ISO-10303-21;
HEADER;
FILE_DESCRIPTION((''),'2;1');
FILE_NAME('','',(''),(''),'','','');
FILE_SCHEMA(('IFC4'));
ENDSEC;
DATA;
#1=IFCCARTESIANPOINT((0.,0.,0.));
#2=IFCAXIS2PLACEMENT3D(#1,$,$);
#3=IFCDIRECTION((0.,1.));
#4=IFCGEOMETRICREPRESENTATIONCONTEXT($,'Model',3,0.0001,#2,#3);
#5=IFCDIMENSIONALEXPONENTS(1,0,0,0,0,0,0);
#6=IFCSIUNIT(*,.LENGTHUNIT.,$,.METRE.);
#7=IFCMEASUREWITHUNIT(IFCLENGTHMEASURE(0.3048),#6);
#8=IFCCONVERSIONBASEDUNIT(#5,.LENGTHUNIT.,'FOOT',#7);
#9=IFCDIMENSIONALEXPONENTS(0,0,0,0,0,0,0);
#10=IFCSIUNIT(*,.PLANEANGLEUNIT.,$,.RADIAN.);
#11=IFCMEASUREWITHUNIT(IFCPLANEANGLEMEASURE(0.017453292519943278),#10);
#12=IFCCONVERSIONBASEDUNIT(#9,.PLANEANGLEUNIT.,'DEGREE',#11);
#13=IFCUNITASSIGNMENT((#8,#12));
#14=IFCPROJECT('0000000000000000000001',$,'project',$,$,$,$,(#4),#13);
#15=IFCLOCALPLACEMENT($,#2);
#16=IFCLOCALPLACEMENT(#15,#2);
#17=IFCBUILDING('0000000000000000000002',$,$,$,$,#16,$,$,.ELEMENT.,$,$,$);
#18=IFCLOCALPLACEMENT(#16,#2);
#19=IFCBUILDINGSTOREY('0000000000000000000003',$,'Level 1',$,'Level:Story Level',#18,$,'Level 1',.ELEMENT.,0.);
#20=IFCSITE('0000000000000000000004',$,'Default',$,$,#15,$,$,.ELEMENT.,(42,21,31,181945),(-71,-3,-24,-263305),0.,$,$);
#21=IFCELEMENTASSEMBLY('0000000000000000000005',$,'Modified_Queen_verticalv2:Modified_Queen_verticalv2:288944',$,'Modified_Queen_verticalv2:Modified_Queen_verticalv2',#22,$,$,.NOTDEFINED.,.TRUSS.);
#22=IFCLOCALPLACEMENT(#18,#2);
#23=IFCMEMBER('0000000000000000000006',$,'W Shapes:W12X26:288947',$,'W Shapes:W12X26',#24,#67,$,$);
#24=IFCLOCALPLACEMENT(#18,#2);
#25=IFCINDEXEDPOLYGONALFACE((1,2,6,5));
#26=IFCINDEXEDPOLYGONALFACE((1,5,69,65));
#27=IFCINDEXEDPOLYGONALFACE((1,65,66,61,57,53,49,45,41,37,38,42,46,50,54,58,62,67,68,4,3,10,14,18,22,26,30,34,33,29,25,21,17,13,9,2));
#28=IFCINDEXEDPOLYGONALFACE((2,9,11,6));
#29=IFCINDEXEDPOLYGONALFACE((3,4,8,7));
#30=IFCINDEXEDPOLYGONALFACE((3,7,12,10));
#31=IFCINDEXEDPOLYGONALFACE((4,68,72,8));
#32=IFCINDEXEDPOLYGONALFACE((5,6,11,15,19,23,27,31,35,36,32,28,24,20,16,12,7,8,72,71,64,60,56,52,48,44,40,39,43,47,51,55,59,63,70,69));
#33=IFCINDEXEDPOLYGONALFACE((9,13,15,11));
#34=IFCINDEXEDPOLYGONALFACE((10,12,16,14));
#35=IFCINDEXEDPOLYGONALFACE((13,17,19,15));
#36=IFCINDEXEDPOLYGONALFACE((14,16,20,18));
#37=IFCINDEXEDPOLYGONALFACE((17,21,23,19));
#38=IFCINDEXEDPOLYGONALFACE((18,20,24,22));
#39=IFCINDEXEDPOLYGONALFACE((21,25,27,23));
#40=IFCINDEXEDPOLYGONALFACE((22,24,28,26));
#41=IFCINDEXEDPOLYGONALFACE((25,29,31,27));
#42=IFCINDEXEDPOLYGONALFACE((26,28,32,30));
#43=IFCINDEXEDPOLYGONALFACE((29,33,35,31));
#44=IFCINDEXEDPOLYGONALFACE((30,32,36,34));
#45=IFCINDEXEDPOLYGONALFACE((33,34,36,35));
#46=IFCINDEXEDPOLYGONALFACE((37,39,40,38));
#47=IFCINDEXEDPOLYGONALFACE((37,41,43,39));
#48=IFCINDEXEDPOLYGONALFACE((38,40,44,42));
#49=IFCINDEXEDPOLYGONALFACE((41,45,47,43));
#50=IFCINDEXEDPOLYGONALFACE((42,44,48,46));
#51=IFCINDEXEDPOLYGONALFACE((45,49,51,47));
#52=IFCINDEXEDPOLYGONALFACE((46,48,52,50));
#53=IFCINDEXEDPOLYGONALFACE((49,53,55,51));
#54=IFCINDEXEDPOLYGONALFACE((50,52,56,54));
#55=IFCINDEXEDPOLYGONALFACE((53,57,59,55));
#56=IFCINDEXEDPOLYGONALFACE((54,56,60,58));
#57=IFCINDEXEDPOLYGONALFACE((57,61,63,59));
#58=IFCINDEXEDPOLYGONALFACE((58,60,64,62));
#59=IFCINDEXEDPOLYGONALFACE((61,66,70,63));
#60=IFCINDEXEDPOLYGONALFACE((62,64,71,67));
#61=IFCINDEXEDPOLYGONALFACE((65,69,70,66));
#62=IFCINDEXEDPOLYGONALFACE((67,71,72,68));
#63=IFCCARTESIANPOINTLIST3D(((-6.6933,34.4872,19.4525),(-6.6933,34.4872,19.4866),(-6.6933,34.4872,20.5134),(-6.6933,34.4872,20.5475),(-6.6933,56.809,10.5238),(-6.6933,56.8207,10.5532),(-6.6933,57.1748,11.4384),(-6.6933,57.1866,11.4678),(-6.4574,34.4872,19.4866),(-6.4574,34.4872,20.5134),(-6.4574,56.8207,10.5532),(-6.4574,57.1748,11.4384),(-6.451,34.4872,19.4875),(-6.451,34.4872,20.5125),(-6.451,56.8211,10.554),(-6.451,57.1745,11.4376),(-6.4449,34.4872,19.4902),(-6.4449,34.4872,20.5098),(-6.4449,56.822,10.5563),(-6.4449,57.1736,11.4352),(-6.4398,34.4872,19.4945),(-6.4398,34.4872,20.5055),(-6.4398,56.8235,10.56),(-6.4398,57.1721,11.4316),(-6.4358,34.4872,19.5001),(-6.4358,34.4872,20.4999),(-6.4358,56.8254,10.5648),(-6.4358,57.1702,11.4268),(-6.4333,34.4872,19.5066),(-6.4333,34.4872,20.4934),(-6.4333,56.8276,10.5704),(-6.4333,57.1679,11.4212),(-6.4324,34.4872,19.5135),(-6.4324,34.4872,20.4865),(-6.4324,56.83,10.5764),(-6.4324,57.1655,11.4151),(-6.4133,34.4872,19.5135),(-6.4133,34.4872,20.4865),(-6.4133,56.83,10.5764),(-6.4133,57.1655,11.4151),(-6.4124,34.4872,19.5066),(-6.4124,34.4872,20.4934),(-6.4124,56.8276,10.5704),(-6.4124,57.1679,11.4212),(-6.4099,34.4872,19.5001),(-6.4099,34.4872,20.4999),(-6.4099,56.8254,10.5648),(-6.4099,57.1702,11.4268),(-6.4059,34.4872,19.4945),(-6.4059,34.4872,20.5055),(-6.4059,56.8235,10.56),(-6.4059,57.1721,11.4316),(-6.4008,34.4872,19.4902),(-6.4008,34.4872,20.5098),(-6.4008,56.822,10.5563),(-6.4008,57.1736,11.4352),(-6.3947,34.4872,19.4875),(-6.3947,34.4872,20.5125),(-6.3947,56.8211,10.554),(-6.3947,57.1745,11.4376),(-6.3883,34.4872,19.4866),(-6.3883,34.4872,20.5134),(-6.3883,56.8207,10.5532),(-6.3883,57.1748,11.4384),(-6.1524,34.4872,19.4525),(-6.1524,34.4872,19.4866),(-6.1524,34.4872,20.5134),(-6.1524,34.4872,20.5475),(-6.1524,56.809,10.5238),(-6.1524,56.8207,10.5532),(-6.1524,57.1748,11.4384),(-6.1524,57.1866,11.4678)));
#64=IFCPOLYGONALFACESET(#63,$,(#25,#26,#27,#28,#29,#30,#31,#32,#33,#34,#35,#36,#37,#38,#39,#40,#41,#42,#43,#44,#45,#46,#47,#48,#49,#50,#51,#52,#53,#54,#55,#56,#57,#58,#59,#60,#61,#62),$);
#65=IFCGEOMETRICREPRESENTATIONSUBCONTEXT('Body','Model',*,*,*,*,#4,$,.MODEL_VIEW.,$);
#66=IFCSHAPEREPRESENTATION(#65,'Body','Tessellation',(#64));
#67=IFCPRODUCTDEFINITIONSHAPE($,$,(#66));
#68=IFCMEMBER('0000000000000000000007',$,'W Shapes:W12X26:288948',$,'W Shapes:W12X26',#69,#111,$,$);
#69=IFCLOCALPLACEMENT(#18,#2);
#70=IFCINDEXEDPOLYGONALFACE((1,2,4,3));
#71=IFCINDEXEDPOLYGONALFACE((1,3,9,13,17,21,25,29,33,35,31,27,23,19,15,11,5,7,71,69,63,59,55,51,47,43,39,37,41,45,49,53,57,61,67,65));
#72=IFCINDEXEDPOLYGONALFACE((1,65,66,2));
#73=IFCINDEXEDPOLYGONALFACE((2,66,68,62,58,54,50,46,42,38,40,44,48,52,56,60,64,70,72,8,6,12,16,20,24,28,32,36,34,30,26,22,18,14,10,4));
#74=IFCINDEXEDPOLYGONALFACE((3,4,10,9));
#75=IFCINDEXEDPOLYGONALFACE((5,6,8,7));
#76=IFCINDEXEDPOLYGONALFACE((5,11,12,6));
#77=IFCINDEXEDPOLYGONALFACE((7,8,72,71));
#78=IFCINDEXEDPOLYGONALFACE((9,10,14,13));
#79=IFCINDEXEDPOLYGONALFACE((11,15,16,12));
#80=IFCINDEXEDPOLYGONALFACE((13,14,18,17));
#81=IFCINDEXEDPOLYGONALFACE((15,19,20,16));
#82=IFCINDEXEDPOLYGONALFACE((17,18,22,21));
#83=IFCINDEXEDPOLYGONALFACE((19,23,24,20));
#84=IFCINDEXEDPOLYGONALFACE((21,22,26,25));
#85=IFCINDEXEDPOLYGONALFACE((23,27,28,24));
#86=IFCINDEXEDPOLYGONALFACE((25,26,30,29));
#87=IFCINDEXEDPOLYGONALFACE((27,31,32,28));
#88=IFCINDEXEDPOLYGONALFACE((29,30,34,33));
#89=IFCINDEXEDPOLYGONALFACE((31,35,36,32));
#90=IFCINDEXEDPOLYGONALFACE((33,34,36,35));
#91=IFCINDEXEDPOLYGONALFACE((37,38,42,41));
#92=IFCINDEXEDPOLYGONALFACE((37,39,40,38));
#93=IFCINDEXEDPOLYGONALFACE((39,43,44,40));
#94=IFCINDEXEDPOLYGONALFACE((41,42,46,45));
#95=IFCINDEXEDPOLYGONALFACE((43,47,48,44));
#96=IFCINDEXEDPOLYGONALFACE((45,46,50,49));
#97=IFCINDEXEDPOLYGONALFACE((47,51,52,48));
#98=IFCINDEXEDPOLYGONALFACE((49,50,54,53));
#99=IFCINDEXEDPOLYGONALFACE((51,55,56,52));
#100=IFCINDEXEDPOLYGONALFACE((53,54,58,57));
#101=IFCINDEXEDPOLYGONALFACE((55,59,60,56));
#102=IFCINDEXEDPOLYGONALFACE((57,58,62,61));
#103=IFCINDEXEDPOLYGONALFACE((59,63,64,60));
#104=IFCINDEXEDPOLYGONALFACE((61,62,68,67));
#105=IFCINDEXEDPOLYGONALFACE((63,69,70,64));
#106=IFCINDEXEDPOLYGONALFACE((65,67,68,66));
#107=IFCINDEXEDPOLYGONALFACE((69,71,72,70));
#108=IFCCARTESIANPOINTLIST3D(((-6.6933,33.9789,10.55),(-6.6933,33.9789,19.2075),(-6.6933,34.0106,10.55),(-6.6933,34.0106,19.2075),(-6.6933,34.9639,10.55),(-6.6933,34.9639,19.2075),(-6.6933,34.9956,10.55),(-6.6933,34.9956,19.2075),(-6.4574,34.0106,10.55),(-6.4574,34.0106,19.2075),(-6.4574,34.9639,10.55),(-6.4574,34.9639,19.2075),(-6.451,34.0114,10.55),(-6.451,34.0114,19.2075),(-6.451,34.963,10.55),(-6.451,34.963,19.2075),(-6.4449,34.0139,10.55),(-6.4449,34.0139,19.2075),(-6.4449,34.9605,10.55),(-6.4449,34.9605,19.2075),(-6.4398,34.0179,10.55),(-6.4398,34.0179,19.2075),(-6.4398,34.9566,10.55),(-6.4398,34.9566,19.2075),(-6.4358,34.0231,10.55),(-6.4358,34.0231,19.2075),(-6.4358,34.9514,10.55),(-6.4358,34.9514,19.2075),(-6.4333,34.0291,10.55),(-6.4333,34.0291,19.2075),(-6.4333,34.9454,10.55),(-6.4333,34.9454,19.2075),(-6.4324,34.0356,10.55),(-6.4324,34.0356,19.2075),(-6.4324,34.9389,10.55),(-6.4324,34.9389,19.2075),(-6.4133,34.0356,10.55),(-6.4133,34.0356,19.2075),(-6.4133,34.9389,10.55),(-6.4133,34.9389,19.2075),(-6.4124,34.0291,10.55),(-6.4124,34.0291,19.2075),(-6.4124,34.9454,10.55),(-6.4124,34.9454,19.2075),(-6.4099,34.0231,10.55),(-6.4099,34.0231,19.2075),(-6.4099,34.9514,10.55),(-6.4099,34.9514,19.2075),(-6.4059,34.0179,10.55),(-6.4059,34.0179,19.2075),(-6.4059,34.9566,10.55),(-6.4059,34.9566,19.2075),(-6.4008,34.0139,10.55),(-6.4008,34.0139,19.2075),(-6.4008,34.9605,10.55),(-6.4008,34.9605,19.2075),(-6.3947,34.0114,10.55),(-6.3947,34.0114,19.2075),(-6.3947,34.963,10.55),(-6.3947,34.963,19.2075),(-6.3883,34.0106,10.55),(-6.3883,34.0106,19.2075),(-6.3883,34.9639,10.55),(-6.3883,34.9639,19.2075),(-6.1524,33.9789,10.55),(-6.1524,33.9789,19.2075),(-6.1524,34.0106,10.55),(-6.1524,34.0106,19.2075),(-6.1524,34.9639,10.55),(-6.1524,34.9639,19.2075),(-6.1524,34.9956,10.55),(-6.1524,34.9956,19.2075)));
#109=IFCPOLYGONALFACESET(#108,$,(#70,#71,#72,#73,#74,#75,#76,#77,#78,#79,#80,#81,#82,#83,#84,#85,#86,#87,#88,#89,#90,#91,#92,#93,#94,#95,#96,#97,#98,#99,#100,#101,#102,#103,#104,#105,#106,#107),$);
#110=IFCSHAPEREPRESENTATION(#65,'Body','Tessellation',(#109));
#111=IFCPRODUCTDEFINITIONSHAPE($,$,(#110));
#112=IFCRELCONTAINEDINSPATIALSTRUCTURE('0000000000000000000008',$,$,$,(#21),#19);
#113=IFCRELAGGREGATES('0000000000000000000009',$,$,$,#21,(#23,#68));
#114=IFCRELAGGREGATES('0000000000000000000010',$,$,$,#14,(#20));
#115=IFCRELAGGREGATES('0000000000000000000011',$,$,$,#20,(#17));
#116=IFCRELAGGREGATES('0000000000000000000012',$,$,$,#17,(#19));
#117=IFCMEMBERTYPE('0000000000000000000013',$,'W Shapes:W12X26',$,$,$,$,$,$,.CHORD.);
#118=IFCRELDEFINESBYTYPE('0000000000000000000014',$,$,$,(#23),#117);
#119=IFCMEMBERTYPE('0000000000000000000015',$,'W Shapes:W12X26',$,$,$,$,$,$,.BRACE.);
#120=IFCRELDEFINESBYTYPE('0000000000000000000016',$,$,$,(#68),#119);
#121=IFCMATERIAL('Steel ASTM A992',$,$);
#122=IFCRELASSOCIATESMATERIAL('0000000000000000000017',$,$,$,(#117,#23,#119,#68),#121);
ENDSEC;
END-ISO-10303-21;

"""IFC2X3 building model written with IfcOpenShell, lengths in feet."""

from ifc_helpers import new_model, entity, si_unit, converted_unit, direction, frame, frame_2d, origin, place, context, subcontext, project, spatial, polyline, circle_curve, parameter, trimmed, segment, composite_curve, outline, extrude, clip, halfspace, source, transform, mapped, material, type_object, type_shapes, element, aggregate, save


model = new_model("IFC2X3")

# Units and contexts
model_context = context("Model", 3, precision=0.0001, world=origin(), true_north=direction((0.0, 1.0)))
body_context = subcontext(model_context, "Body", "Model", "MODEL_VIEW")
ifc_project = project(units=[converted_unit("LENGTHUNIT", "FOOT", entity("IfcLengthMeasure", 0.3048), si_unit("LENGTHUNIT", "METRE"), dimensions=[1, 0, 0, 0, 0, 0, 0]), converted_unit("PLANEANGLEUNIT", "DEGREE", entity("IfcPlaneAngleMeasure", 0.017453292519943278), si_unit("PLANEANGLEUNIT", "RADIAN"), dimensions=[0, 0, 0, 0, 0, 0, 0])], contexts=[model_context])

# Site, building, storey
site_placement = place(None, origin())
site = spatial("IfcSite", under=ifc_project, at=site_placement, Name="Default", CompositionType="ELEMENT", RefLatitude=(42, 21, 31, 181945), RefLongitude=(-71, -3, -24, -263305), RefElevation=0.0)
building_placement = place(site_placement, origin())
building = spatial("IfcBuilding", under=site, at=building_placement, CompositionType="ELEMENT")
storey_placement = place(building_placement, origin())
storey = spatial("IfcBuildingStorey", under=building, at=storey_placement, Name="Level 1", ObjectType="Level:Story Level", LongName="Level 1", CompositionType="ELEMENT", Elevation=0.0)

# Element assembly, members
assembly_placement = place(storey_placement, origin())
assembly = element("IfcElementAssembly", 1, at=assembly_placement, inside=storey, Name="Modified_Queen_verticalv2:Modified_Queen_verticalv2:288944", ObjectType="Modified_Queen_verticalv2:Modified_Queen_verticalv2", AssemblyPlace="NOTDEFINED", PredefinedType="TRUSS")
ifc_material = material(Name="Steel ASTM A992")
member_type_1 = type_object("IfcMemberType", Name="W Shapes:W12X26", PredefinedType="CHORD", material=ifc_material)
shared_shape_1 = source(origin(), body_context, "Body", "SweptSolid", [
    clip(extrude(outline(composite_curve([segment(polyline([(0.4767, -0.2704), (0.5083, -0.2704)]), True, "CONTINUOUS"), segment(polyline([(0.5083, -0.2704), (0.5083, 0.2704)]), True, "CONTINUOUS"), segment(polyline([(0.5083, 0.2704), (0.4767, 0.2704)]), True, "CONTINUOUS"), segment(polyline([(0.4767, 0.2704), (0.4767, 0.0346)]), True, "CONTINUOUS"), segment(trimmed(circle_curve(frame_2d((0.4517, 0.0346), x_axis=(1.0, 0.0)), 0.025), [parameter(270.0)], [parameter(0.0)], True, "PARAMETER"), False, "CONTINUOUS"), segment(polyline([(0.4517, 0.0096), (-0.4517, 0.0096)]), True, "CONTINUOUS"), segment(trimmed(circle_curve(frame_2d((-0.4517, 0.0346), x_axis=(0.0, -1.0)), 0.025), [parameter(270.0)], [parameter(0.0)], True, "PARAMETER"), False, "CONTINUOUS"), segment(polyline([(-0.4767, 0.0346), (-0.4767, 0.2704)]), True, "CONTINUOUS"), segment(polyline([(-0.4767, 0.2704), (-0.5083, 0.2704)]), True, "CONTINUOUS"), segment(polyline([(-0.5083, 0.2704), (-0.5083, -0.2704)]), True, "CONTINUOUS"), segment(polyline([(-0.5083, -0.2704), (-0.4767, -0.2704)]), True, "CONTINUOUS"), segment(polyline([(-0.4767, -0.2704), (-0.4767, -0.0346)]), True, "CONTINUOUS"), segment(trimmed(circle_curve(frame_2d((-0.4517, -0.0346), x_axis=(-1.0, 0.0)), 0.025), [parameter(270.0)], [parameter(0.0)], True, "PARAMETER"), False, "CONTINUOUS"), segment(polyline([(-0.4517, -0.0096), (0.4517, -0.0096)]), True, "CONTINUOUS"), segment(trimmed(circle_curve(frame_2d((0.4517, -0.0346), x_axis=(0.0, 1.0)), 0.025), [parameter(270.0)], [parameter(0.0)], True, "PARAMETER"), False, "CONTINUOUS"), segment(polyline([(0.4767, -0.0346), (0.4767, -0.2704)]), True, "CONTINUOUS")], self_intersect=False)), frame((-6.4228, 34.2984, 20.0755), z_axis=(0.0, 0.928477, -0.371391), x_axis=(0.0, 0.371391, 0.928477)), (0.0, 0.0, 1.0), 24.4479), halfspace(frame((-6.4228, 34.4872, 20.5475), z_axis=(0.0, -1.0, 0.0), x_axis=(0.0, 0.0, 1.0)), False)),
])
type_shapes(member_type_1, [shared_shape_1])
member_1_placement = place(assembly_placement, origin())
member_1 = element("IfcMember", 2, at=member_1_placement, type_object=member_type_1, material=ifc_material, Name="W Shapes:W12X26:288947", ObjectType="W Shapes:W12X26", context=body_context, shape_type="MappedRepresentation", body=[
    mapped(shared_shape_1, transform((0.0, 0.0, 0.0), scale=1.0)),
])
member_type_2 = type_object("IfcMemberType", Name="W Shapes:W12X26", PredefinedType="BRACE", material=ifc_material)
shared_shape_2 = source(origin(), body_context, "Body", "SweptSolid", [
    extrude(outline(composite_curve([segment(polyline([(-0.2704, -0.4767), (-0.2704, -0.5083)]), True, "CONTINUOUS"), segment(polyline([(-0.2704, -0.5083), (0.2704, -0.5083)]), True, "CONTINUOUS"), segment(polyline([(0.2704, -0.5083), (0.2704, -0.4767)]), True, "CONTINUOUS"), segment(polyline([(0.2704, -0.4767), (0.0346, -0.4767)]), True, "CONTINUOUS"), segment(trimmed(circle_curve(frame_2d((0.0346, -0.4517), x_axis=(1.0, 0.0)), 0.025), [parameter(180.0)], [parameter(270.0)], True, "PARAMETER"), False, "CONTINUOUS"), segment(polyline([(0.0096, -0.4517), (0.0096, 0.4517)]), True, "CONTINUOUS"), segment(trimmed(circle_curve(frame_2d((0.0346, 0.4517), x_axis=(1.0, 0.0)), 0.025), [parameter(90.0)], [parameter(180.0)], True, "PARAMETER"), False, "CONTINUOUS"), segment(polyline([(0.0346, 0.4767), (0.2704, 0.4767)]), True, "CONTINUOUS"), segment(polyline([(0.2704, 0.4767), (0.2704, 0.5083)]), True, "CONTINUOUS"), segment(polyline([(0.2704, 0.5083), (-0.2704, 0.5083)]), True, "CONTINUOUS"), segment(polyline([(-0.2704, 0.5083), (-0.2704, 0.4767)]), True, "CONTINUOUS"), segment(polyline([(-0.2704, 0.4767), (-0.0346, 0.4767)]), True, "CONTINUOUS"), segment(trimmed(circle_curve(frame_2d((-0.0346, 0.4517), x_axis=(1.0, 0.0)), 0.025), [parameter(360.0)], [parameter(90.0)], True, "PARAMETER"), False, "CONTINUOUS"), segment(polyline([(-0.0096, 0.4517), (-0.0096, -0.4517)]), True, "CONTINUOUS"), segment(trimmed(circle_curve(frame_2d((-0.0346, -0.4517), x_axis=(1.0, 0.0)), 0.025), [parameter(270.0)], [parameter(360.0)], True, "PARAMETER"), False, "CONTINUOUS"), segment(polyline([(-0.0346, -0.4767), (-0.2704, -0.4767)]), True, "CONTINUOUS")], self_intersect=False)), frame((-4.45, 0.0, 0.0), z_axis=(-1.0, 0.0, 0.0), x_axis=(0.0, -1.0, 0.0)), (0.0, 0.0, -1.0), 8.6575),
])
type_shapes(member_type_2, [shared_shape_2])
member_2_placement = place(assembly_placement, frame((-6.4228, 34.4872, 15.0), z_axis=(0.0, 1.0, 0.0), x_axis=(0.0, 0.0, 1.0)))
member_2 = element("IfcMember", 3, at=member_2_placement, type_object=member_type_2, material=ifc_material, Name="W Shapes:W12X26:288948", ObjectType="W Shapes:W12X26", context=body_context, shape_type="MappedRepresentation", body=[
    mapped(shared_shape_2, transform((0.0, 0.0, 0.0), scale=1.0)),
])
aggregate(assembly, [member_1, member_2])

save(model, "model.ifc")
